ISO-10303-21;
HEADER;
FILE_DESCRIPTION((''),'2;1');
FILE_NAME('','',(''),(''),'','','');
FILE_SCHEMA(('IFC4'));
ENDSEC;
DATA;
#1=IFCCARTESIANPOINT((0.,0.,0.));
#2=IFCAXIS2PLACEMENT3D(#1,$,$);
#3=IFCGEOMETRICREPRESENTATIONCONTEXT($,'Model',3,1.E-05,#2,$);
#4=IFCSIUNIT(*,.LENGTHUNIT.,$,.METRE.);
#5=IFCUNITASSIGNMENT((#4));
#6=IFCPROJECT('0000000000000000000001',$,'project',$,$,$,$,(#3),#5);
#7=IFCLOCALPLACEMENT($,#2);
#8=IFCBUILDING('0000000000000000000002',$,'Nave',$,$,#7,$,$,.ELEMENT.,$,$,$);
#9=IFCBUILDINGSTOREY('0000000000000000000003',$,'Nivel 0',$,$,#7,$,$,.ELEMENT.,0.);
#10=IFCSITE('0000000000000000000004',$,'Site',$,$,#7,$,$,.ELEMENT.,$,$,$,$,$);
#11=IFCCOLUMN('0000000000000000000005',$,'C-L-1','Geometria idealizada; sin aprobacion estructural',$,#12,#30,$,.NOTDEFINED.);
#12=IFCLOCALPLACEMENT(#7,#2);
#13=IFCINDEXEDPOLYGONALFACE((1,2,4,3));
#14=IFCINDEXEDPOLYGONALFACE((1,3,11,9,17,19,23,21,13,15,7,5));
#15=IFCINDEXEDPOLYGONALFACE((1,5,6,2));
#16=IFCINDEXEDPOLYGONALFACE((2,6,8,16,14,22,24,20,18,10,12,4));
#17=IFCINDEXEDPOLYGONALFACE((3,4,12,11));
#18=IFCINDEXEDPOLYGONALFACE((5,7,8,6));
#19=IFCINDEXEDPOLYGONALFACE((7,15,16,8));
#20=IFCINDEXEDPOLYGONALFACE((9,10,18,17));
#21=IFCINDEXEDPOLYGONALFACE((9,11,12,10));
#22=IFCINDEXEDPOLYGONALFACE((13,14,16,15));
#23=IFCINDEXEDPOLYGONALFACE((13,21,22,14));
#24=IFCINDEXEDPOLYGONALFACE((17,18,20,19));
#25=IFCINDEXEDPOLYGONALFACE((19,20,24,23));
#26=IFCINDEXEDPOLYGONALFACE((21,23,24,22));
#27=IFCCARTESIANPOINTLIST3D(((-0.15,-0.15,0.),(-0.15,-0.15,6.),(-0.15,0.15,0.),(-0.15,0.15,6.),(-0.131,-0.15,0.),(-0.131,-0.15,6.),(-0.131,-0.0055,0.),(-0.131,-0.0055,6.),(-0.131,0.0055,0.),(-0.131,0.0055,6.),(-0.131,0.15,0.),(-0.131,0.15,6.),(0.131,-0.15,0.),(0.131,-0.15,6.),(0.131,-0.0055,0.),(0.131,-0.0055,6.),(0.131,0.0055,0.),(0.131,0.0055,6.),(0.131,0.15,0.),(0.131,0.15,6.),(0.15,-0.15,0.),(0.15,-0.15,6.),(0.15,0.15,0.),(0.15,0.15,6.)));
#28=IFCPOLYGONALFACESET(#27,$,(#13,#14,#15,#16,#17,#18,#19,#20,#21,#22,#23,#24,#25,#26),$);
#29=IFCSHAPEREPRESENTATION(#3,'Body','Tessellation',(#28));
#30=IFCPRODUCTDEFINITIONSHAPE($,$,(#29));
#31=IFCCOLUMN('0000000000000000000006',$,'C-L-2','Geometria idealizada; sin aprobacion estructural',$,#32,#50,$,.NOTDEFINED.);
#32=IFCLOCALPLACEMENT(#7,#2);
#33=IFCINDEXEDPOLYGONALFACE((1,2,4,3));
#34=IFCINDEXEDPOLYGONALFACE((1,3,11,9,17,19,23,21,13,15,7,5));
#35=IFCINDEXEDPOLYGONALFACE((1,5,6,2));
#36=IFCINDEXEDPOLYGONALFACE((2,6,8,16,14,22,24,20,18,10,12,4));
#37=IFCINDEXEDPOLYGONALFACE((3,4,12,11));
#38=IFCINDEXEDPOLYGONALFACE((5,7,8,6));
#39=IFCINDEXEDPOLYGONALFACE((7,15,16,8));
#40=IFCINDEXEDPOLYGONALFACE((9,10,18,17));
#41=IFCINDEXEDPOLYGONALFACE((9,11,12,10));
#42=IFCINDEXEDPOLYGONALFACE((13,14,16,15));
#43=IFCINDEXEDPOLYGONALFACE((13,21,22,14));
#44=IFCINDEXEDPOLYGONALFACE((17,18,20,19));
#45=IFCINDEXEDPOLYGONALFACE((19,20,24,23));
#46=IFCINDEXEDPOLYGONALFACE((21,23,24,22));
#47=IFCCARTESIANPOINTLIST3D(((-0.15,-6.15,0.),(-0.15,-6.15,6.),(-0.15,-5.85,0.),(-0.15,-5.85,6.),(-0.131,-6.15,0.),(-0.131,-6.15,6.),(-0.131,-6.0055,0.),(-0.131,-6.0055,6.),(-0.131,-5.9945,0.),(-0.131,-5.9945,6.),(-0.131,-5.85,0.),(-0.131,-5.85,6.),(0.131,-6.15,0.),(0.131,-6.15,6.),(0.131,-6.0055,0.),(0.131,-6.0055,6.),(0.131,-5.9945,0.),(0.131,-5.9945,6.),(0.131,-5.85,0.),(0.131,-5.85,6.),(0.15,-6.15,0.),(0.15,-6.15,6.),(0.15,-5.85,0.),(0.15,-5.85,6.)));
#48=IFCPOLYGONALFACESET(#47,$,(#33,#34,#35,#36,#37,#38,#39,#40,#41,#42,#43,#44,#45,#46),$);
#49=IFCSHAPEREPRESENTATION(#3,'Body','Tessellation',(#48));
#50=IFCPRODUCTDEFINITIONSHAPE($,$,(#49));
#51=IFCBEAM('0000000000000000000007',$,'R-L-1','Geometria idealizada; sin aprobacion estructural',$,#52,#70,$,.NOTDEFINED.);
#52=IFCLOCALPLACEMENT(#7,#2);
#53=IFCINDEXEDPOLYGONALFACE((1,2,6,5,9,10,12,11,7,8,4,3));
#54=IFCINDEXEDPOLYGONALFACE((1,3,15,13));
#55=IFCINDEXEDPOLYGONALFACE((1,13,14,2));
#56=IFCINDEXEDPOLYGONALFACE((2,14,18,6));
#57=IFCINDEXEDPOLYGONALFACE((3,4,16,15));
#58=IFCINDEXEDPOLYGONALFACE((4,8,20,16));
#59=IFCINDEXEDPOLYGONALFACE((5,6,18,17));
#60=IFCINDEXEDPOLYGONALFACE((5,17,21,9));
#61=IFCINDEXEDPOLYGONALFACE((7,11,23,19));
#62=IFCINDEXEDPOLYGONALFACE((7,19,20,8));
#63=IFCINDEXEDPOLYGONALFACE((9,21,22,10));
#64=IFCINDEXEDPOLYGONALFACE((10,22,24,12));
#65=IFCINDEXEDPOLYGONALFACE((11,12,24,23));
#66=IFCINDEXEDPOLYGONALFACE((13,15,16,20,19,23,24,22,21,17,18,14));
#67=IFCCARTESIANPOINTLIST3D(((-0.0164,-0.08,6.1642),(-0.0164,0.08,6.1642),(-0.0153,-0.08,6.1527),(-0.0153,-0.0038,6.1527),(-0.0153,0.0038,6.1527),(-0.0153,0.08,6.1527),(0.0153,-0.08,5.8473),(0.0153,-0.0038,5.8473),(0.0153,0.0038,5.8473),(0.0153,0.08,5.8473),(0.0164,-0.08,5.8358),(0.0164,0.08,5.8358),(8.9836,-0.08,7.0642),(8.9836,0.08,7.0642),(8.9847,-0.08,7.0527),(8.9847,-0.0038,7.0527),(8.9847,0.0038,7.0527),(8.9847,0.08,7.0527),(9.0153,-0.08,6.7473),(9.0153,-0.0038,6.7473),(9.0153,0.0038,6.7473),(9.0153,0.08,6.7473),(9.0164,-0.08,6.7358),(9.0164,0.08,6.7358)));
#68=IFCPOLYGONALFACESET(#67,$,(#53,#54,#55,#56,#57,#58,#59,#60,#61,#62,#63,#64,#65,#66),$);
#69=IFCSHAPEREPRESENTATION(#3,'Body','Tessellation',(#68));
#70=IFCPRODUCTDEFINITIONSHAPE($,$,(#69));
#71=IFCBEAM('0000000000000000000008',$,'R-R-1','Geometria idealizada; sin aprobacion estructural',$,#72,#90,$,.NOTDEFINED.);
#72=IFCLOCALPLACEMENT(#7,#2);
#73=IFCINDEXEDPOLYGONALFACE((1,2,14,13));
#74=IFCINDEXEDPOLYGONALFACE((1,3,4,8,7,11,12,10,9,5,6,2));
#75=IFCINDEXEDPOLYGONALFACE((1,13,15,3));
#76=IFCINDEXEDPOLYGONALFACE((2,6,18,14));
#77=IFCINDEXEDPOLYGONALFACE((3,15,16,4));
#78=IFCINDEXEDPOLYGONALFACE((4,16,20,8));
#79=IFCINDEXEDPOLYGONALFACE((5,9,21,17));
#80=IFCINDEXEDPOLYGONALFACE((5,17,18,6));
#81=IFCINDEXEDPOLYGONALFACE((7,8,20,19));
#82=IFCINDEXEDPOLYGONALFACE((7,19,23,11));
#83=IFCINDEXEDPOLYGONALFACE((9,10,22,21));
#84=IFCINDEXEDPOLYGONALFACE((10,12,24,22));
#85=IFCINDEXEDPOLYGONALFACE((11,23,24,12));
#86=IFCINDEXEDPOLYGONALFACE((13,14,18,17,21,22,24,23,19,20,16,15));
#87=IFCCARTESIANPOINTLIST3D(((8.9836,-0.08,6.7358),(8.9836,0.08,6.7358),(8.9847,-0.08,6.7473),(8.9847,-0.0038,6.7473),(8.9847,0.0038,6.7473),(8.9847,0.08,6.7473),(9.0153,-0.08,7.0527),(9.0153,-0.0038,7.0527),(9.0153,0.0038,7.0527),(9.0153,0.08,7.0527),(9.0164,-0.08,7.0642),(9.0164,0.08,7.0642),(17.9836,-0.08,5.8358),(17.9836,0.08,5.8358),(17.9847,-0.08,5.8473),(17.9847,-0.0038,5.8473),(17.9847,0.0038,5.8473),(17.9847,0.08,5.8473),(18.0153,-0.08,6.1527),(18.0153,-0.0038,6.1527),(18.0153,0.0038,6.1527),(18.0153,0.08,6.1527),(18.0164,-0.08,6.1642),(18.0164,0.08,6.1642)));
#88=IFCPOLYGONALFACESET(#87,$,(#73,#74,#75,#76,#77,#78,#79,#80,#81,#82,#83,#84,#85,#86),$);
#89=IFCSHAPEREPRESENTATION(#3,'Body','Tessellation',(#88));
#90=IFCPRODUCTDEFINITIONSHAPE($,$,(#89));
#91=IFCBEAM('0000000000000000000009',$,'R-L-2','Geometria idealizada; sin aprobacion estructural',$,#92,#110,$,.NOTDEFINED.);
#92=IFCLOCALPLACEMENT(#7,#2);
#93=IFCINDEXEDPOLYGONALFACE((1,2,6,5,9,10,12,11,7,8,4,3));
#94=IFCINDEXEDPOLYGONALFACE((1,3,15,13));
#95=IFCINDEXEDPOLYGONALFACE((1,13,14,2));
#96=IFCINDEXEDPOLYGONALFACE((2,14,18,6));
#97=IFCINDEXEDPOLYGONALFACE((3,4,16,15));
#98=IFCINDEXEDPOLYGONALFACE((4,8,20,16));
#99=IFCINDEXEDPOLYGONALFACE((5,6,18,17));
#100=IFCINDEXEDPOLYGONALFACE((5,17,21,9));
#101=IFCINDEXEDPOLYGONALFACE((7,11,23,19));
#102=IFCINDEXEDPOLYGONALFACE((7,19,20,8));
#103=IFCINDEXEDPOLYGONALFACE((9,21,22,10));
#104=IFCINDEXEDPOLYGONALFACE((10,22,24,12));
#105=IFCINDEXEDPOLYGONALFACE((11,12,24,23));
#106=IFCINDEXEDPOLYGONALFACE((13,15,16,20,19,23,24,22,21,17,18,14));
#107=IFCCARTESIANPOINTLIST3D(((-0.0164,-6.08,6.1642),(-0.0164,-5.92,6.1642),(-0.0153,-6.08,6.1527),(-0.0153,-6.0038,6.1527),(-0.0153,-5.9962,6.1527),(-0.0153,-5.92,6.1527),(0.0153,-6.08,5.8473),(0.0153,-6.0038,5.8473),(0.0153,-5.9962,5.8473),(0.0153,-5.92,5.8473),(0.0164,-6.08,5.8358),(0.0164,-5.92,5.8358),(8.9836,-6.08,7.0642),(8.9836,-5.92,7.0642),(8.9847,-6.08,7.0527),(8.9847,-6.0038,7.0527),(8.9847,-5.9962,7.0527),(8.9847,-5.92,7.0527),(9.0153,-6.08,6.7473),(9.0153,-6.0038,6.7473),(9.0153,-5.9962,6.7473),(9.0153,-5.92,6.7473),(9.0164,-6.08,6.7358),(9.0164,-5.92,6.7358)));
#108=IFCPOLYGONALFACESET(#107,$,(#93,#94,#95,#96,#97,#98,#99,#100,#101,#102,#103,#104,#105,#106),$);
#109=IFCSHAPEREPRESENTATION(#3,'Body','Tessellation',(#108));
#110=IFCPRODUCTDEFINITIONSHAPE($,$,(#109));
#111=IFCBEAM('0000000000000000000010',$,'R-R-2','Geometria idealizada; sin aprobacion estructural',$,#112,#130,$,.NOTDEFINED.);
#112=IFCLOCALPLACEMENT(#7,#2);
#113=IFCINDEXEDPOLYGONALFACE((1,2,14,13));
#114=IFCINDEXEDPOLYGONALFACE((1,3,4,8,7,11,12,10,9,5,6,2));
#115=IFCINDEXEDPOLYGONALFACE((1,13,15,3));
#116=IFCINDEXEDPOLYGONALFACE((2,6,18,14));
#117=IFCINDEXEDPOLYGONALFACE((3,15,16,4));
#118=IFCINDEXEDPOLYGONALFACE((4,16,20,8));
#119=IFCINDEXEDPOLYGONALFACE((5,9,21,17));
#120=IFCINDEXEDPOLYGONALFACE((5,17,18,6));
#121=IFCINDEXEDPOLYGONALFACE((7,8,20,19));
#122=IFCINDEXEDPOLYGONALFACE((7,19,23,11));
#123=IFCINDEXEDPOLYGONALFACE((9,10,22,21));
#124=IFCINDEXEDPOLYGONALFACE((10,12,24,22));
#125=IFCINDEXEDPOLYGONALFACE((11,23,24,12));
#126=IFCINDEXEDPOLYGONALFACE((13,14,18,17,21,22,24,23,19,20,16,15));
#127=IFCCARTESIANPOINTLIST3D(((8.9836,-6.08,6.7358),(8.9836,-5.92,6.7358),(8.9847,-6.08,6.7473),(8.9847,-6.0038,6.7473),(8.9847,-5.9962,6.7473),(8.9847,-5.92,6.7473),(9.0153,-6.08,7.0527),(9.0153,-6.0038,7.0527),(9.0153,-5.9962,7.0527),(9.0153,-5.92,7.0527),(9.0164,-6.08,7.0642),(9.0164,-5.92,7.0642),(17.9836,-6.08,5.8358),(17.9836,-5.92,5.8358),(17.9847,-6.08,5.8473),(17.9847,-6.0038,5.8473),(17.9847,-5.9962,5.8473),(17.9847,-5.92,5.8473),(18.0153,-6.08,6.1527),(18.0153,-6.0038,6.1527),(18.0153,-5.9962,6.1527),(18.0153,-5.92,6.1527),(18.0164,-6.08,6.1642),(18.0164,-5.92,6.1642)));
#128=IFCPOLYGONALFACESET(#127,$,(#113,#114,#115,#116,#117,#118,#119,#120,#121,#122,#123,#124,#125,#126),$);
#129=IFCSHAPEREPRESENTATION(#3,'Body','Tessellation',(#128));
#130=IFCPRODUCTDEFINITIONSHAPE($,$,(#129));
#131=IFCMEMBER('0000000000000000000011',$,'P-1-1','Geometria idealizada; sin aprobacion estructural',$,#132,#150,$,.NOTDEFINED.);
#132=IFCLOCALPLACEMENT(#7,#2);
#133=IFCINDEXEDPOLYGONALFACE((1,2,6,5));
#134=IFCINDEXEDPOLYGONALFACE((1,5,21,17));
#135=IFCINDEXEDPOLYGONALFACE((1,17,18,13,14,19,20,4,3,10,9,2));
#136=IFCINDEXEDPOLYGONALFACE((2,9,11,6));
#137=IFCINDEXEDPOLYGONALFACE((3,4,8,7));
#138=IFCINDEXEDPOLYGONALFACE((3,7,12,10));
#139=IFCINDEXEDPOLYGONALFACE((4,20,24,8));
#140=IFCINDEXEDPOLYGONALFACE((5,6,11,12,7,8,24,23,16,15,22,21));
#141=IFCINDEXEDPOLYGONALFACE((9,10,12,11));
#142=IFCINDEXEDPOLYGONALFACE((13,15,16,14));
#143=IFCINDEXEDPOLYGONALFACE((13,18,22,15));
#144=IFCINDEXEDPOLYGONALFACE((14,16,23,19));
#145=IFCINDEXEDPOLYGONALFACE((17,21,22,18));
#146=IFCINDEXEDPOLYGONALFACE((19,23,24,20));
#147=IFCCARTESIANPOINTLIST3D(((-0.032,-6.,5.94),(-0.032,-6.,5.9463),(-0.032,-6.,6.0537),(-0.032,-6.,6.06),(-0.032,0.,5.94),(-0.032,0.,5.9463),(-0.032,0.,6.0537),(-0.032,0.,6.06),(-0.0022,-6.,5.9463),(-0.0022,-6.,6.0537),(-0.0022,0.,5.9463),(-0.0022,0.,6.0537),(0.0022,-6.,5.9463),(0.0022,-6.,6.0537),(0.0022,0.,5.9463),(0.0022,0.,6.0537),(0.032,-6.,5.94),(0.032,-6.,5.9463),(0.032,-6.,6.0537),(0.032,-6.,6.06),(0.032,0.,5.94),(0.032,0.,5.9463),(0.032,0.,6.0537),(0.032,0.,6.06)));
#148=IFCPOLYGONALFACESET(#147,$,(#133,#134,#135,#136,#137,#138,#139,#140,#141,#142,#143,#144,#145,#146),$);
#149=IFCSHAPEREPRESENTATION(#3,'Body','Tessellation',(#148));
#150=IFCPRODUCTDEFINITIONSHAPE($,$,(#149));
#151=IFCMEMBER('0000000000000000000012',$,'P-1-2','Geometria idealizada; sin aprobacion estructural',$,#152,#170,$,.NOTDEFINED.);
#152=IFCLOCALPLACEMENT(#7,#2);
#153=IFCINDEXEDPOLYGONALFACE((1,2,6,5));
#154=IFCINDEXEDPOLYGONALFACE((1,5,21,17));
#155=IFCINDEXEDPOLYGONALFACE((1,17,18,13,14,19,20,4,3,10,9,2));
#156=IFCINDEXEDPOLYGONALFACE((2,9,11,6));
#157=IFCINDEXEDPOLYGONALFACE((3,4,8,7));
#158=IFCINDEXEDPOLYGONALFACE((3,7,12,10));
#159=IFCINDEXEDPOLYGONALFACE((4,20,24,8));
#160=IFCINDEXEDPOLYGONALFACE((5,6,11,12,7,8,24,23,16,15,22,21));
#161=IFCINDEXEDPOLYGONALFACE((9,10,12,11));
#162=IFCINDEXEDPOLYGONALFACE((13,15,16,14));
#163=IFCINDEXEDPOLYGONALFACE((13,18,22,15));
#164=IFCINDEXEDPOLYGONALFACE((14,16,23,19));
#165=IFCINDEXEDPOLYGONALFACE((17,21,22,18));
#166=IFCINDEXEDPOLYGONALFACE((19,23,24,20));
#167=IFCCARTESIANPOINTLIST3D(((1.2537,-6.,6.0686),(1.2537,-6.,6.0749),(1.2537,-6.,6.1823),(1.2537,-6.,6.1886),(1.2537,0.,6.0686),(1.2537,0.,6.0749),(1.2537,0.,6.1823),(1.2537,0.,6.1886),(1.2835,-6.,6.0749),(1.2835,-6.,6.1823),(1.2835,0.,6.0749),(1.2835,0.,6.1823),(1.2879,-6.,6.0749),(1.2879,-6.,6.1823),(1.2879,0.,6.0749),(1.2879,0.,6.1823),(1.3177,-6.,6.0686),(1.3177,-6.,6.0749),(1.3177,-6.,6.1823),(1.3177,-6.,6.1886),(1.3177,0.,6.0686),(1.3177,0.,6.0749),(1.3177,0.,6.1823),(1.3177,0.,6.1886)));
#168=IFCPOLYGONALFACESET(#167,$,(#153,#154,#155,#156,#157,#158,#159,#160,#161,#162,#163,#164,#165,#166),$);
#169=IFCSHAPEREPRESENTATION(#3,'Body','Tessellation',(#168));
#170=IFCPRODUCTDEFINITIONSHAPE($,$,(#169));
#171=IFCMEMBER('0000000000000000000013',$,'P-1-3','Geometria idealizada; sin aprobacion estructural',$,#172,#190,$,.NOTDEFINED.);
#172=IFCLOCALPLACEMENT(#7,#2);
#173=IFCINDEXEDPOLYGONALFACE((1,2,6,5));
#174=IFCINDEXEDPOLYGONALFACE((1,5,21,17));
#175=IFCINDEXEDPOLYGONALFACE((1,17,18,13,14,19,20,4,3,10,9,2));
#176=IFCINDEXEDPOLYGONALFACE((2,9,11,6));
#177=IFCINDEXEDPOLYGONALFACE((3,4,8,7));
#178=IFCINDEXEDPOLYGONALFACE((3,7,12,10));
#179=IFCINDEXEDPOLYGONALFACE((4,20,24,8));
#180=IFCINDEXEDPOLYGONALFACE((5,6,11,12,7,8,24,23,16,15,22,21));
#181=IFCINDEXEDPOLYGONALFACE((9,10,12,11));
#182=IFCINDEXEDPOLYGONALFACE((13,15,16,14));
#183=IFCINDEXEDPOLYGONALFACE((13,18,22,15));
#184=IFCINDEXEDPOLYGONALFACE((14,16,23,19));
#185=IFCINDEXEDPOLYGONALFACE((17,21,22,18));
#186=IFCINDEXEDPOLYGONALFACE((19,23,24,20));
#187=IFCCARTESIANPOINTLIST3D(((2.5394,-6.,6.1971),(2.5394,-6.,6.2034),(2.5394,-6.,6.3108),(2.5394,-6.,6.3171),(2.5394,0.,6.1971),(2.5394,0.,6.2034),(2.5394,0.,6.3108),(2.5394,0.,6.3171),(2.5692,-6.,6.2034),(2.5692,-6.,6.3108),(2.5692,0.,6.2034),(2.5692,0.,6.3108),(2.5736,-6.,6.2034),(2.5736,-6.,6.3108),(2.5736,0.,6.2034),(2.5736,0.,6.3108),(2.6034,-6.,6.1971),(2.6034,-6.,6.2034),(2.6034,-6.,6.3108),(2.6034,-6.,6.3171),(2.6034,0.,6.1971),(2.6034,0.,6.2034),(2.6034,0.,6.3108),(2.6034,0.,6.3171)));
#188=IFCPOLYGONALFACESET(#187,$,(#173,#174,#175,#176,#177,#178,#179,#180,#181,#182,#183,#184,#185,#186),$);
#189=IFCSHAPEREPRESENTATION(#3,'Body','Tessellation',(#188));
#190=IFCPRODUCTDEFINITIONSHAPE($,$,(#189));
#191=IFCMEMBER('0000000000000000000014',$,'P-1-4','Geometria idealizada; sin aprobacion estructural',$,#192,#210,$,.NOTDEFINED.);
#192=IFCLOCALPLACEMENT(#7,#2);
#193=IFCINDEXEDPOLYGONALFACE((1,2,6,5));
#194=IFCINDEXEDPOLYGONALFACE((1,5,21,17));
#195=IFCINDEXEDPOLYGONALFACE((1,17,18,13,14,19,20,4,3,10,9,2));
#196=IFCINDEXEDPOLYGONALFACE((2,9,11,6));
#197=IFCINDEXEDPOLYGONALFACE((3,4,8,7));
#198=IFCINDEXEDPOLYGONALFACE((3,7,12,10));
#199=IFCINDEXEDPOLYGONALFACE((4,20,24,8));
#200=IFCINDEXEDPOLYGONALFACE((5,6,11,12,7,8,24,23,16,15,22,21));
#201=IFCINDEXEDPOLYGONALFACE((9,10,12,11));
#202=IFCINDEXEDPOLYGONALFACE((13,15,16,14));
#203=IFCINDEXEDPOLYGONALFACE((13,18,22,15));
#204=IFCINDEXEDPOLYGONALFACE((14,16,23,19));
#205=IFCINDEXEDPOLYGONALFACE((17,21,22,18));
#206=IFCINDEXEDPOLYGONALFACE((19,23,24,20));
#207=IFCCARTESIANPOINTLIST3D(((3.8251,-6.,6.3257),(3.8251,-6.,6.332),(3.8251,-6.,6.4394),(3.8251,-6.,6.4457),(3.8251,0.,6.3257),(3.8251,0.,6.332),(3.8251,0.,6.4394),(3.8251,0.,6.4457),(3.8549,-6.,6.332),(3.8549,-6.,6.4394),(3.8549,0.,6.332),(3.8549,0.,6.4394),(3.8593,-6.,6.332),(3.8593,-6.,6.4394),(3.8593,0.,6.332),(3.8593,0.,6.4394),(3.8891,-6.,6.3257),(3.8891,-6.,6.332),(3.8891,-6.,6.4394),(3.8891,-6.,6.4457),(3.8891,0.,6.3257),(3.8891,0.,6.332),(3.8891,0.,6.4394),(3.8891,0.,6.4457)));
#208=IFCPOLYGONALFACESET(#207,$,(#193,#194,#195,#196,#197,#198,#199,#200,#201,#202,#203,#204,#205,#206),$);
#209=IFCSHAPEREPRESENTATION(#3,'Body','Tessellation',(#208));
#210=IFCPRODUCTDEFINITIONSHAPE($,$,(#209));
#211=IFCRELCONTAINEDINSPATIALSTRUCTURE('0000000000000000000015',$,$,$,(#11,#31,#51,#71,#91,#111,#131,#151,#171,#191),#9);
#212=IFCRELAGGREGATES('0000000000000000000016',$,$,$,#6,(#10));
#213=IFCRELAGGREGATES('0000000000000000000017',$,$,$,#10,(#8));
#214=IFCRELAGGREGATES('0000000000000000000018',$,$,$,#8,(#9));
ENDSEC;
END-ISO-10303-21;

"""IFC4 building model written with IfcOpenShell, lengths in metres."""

from ifc_helpers import new_model, si_unit, frame, origin, place, context, project, spatial, polyline, outline, extrude, element, save


model = new_model("IFC4")

# Units and contexts
model_context = context("Model", 3, precision=1e-05, world=origin())
ifc_project = project(units=[si_unit("LENGTHUNIT", "METRE")], contexts=[model_context])

# Site, building, storey
placement = place(None, origin())
site = spatial("IfcSite", under=ifc_project, at=placement, Name="Site", CompositionType="ELEMENT")
building = spatial("IfcBuilding", under=site, at=placement, Name="Nave", CompositionType="ELEMENT")
storey = spatial("IfcBuildingStorey", under=building, at=placement, Name="Nivel 0", CompositionType="ELEMENT", Elevation=0.0)

# Columns
for number, where, z_axis, x_axis, name in (
    (1, (0.0, 0.0, 0.0), (0.0, 0.0, 1.0), (0.0, -1.0, 0.0), "C-L-1"),
    (2, (0.0, -6.0, 0.0), (0.0, 0.0, 1.0), (0.0, -1.0, 0.0), "C-L-2"),
):
    element("IfcColumn", number, at=place(placement, frame(where, z_axis=z_axis, x_axis=x_axis)), inside=storey, Name=name, Description="Geometria idealizada; sin aprobacion estructural", PredefinedType="NOTDEFINED", context=model_context, shape_type="SweptSolid", body=[
        extrude(outline(polyline([(-0.15, -0.15), (0.15, -0.15), (0.15, -0.131), (0.0055, -0.131), (0.0055, 0.131), (0.15, 0.131), (0.15, 0.15), (-0.15, 0.15), (-0.15, 0.131), (-0.0055, 0.131), (-0.0055, -0.131), (-0.15, -0.131), (-0.15, -0.15)])), origin(), (0.0, 0.0, 1.0), 6.0),
    ])

# Beams
for number, where, z_axis, x_axis, name in (
    (3, (0.0, 0.0, 6.0), (0.995037, 0.0, 0.099504), (0.0, 1.0, 0.0), "R-L-1"),
    (4, (9.0, 0.0, 6.9), (0.995037, 0.0, -0.099504), (0.0, 1.0, 0.0), "R-R-1"),
    (5, (0.0, -6.0, 6.0), (0.995037, 0.0, 0.099504), (0.0, 1.0, 0.0), "R-L-2"),
    (6, (9.0, -6.0, 6.9), (0.995037, 0.0, -0.099504), (0.0, 1.0, 0.0), "R-R-2"),
):
    element("IfcBeam", number, at=place(placement, frame(where, z_axis=z_axis, x_axis=x_axis)), inside=storey, Name=name, Description="Geometria idealizada; sin aprobacion estructural", PredefinedType="NOTDEFINED", context=model_context, shape_type="SweptSolid", body=[
        extrude(outline(polyline([(-0.08, -0.165), (0.08, -0.165), (0.08, -0.1535), (0.0037, -0.1535), (0.0037, 0.1535), (0.08, 0.1535), (0.08, 0.165), (-0.08, 0.165), (-0.08, 0.1535), (-0.0037, 0.1535), (-0.0037, -0.1535), (-0.08, -0.1535), (-0.08, -0.165)])), origin(), (0.0, 0.0, 1.0), 9.0449),
    ])

# Members
for number, where, z_axis, x_axis, name in (
    (7, (0.0, 0.0, 6.0), (0.0, -1.0, 0.0), (1.0, 0.0, 0.0), "P-1-1"),
    (8, (1.2857, 0.0, 6.1286), (0.0, -1.0, 0.0), (1.0, 0.0, 0.0), "P-1-2"),
    (9, (2.5714, 0.0, 6.2571), (0.0, -1.0, 0.0), (1.0, 0.0, 0.0), "P-1-3"),
    (10, (3.8571, 0.0, 6.3857), (0.0, -1.0, 0.0), (1.0, 0.0, 0.0), "P-1-4"),
):
    element("IfcMember", number, at=place(placement, frame(where, z_axis=z_axis, x_axis=x_axis)), inside=storey, Name=name, Description="Geometria idealizada; sin aprobacion estructural", PredefinedType="NOTDEFINED", context=model_context, shape_type="SweptSolid", body=[
        extrude(outline(polyline([(-0.032, -0.06), (0.032, -0.06), (0.032, -0.0537), (0.0022, -0.0537), (0.0022, 0.0537), (0.032, 0.0537), (0.032, 0.06), (-0.032, 0.06), (-0.032, 0.0537), (-0.0022, 0.0537), (-0.0022, -0.0537), (-0.032, -0.0537), (-0.032, -0.06)])), origin(), (0.0, 0.0, 1.0), 6.0),
    ])

save(model, "model.ifc")
